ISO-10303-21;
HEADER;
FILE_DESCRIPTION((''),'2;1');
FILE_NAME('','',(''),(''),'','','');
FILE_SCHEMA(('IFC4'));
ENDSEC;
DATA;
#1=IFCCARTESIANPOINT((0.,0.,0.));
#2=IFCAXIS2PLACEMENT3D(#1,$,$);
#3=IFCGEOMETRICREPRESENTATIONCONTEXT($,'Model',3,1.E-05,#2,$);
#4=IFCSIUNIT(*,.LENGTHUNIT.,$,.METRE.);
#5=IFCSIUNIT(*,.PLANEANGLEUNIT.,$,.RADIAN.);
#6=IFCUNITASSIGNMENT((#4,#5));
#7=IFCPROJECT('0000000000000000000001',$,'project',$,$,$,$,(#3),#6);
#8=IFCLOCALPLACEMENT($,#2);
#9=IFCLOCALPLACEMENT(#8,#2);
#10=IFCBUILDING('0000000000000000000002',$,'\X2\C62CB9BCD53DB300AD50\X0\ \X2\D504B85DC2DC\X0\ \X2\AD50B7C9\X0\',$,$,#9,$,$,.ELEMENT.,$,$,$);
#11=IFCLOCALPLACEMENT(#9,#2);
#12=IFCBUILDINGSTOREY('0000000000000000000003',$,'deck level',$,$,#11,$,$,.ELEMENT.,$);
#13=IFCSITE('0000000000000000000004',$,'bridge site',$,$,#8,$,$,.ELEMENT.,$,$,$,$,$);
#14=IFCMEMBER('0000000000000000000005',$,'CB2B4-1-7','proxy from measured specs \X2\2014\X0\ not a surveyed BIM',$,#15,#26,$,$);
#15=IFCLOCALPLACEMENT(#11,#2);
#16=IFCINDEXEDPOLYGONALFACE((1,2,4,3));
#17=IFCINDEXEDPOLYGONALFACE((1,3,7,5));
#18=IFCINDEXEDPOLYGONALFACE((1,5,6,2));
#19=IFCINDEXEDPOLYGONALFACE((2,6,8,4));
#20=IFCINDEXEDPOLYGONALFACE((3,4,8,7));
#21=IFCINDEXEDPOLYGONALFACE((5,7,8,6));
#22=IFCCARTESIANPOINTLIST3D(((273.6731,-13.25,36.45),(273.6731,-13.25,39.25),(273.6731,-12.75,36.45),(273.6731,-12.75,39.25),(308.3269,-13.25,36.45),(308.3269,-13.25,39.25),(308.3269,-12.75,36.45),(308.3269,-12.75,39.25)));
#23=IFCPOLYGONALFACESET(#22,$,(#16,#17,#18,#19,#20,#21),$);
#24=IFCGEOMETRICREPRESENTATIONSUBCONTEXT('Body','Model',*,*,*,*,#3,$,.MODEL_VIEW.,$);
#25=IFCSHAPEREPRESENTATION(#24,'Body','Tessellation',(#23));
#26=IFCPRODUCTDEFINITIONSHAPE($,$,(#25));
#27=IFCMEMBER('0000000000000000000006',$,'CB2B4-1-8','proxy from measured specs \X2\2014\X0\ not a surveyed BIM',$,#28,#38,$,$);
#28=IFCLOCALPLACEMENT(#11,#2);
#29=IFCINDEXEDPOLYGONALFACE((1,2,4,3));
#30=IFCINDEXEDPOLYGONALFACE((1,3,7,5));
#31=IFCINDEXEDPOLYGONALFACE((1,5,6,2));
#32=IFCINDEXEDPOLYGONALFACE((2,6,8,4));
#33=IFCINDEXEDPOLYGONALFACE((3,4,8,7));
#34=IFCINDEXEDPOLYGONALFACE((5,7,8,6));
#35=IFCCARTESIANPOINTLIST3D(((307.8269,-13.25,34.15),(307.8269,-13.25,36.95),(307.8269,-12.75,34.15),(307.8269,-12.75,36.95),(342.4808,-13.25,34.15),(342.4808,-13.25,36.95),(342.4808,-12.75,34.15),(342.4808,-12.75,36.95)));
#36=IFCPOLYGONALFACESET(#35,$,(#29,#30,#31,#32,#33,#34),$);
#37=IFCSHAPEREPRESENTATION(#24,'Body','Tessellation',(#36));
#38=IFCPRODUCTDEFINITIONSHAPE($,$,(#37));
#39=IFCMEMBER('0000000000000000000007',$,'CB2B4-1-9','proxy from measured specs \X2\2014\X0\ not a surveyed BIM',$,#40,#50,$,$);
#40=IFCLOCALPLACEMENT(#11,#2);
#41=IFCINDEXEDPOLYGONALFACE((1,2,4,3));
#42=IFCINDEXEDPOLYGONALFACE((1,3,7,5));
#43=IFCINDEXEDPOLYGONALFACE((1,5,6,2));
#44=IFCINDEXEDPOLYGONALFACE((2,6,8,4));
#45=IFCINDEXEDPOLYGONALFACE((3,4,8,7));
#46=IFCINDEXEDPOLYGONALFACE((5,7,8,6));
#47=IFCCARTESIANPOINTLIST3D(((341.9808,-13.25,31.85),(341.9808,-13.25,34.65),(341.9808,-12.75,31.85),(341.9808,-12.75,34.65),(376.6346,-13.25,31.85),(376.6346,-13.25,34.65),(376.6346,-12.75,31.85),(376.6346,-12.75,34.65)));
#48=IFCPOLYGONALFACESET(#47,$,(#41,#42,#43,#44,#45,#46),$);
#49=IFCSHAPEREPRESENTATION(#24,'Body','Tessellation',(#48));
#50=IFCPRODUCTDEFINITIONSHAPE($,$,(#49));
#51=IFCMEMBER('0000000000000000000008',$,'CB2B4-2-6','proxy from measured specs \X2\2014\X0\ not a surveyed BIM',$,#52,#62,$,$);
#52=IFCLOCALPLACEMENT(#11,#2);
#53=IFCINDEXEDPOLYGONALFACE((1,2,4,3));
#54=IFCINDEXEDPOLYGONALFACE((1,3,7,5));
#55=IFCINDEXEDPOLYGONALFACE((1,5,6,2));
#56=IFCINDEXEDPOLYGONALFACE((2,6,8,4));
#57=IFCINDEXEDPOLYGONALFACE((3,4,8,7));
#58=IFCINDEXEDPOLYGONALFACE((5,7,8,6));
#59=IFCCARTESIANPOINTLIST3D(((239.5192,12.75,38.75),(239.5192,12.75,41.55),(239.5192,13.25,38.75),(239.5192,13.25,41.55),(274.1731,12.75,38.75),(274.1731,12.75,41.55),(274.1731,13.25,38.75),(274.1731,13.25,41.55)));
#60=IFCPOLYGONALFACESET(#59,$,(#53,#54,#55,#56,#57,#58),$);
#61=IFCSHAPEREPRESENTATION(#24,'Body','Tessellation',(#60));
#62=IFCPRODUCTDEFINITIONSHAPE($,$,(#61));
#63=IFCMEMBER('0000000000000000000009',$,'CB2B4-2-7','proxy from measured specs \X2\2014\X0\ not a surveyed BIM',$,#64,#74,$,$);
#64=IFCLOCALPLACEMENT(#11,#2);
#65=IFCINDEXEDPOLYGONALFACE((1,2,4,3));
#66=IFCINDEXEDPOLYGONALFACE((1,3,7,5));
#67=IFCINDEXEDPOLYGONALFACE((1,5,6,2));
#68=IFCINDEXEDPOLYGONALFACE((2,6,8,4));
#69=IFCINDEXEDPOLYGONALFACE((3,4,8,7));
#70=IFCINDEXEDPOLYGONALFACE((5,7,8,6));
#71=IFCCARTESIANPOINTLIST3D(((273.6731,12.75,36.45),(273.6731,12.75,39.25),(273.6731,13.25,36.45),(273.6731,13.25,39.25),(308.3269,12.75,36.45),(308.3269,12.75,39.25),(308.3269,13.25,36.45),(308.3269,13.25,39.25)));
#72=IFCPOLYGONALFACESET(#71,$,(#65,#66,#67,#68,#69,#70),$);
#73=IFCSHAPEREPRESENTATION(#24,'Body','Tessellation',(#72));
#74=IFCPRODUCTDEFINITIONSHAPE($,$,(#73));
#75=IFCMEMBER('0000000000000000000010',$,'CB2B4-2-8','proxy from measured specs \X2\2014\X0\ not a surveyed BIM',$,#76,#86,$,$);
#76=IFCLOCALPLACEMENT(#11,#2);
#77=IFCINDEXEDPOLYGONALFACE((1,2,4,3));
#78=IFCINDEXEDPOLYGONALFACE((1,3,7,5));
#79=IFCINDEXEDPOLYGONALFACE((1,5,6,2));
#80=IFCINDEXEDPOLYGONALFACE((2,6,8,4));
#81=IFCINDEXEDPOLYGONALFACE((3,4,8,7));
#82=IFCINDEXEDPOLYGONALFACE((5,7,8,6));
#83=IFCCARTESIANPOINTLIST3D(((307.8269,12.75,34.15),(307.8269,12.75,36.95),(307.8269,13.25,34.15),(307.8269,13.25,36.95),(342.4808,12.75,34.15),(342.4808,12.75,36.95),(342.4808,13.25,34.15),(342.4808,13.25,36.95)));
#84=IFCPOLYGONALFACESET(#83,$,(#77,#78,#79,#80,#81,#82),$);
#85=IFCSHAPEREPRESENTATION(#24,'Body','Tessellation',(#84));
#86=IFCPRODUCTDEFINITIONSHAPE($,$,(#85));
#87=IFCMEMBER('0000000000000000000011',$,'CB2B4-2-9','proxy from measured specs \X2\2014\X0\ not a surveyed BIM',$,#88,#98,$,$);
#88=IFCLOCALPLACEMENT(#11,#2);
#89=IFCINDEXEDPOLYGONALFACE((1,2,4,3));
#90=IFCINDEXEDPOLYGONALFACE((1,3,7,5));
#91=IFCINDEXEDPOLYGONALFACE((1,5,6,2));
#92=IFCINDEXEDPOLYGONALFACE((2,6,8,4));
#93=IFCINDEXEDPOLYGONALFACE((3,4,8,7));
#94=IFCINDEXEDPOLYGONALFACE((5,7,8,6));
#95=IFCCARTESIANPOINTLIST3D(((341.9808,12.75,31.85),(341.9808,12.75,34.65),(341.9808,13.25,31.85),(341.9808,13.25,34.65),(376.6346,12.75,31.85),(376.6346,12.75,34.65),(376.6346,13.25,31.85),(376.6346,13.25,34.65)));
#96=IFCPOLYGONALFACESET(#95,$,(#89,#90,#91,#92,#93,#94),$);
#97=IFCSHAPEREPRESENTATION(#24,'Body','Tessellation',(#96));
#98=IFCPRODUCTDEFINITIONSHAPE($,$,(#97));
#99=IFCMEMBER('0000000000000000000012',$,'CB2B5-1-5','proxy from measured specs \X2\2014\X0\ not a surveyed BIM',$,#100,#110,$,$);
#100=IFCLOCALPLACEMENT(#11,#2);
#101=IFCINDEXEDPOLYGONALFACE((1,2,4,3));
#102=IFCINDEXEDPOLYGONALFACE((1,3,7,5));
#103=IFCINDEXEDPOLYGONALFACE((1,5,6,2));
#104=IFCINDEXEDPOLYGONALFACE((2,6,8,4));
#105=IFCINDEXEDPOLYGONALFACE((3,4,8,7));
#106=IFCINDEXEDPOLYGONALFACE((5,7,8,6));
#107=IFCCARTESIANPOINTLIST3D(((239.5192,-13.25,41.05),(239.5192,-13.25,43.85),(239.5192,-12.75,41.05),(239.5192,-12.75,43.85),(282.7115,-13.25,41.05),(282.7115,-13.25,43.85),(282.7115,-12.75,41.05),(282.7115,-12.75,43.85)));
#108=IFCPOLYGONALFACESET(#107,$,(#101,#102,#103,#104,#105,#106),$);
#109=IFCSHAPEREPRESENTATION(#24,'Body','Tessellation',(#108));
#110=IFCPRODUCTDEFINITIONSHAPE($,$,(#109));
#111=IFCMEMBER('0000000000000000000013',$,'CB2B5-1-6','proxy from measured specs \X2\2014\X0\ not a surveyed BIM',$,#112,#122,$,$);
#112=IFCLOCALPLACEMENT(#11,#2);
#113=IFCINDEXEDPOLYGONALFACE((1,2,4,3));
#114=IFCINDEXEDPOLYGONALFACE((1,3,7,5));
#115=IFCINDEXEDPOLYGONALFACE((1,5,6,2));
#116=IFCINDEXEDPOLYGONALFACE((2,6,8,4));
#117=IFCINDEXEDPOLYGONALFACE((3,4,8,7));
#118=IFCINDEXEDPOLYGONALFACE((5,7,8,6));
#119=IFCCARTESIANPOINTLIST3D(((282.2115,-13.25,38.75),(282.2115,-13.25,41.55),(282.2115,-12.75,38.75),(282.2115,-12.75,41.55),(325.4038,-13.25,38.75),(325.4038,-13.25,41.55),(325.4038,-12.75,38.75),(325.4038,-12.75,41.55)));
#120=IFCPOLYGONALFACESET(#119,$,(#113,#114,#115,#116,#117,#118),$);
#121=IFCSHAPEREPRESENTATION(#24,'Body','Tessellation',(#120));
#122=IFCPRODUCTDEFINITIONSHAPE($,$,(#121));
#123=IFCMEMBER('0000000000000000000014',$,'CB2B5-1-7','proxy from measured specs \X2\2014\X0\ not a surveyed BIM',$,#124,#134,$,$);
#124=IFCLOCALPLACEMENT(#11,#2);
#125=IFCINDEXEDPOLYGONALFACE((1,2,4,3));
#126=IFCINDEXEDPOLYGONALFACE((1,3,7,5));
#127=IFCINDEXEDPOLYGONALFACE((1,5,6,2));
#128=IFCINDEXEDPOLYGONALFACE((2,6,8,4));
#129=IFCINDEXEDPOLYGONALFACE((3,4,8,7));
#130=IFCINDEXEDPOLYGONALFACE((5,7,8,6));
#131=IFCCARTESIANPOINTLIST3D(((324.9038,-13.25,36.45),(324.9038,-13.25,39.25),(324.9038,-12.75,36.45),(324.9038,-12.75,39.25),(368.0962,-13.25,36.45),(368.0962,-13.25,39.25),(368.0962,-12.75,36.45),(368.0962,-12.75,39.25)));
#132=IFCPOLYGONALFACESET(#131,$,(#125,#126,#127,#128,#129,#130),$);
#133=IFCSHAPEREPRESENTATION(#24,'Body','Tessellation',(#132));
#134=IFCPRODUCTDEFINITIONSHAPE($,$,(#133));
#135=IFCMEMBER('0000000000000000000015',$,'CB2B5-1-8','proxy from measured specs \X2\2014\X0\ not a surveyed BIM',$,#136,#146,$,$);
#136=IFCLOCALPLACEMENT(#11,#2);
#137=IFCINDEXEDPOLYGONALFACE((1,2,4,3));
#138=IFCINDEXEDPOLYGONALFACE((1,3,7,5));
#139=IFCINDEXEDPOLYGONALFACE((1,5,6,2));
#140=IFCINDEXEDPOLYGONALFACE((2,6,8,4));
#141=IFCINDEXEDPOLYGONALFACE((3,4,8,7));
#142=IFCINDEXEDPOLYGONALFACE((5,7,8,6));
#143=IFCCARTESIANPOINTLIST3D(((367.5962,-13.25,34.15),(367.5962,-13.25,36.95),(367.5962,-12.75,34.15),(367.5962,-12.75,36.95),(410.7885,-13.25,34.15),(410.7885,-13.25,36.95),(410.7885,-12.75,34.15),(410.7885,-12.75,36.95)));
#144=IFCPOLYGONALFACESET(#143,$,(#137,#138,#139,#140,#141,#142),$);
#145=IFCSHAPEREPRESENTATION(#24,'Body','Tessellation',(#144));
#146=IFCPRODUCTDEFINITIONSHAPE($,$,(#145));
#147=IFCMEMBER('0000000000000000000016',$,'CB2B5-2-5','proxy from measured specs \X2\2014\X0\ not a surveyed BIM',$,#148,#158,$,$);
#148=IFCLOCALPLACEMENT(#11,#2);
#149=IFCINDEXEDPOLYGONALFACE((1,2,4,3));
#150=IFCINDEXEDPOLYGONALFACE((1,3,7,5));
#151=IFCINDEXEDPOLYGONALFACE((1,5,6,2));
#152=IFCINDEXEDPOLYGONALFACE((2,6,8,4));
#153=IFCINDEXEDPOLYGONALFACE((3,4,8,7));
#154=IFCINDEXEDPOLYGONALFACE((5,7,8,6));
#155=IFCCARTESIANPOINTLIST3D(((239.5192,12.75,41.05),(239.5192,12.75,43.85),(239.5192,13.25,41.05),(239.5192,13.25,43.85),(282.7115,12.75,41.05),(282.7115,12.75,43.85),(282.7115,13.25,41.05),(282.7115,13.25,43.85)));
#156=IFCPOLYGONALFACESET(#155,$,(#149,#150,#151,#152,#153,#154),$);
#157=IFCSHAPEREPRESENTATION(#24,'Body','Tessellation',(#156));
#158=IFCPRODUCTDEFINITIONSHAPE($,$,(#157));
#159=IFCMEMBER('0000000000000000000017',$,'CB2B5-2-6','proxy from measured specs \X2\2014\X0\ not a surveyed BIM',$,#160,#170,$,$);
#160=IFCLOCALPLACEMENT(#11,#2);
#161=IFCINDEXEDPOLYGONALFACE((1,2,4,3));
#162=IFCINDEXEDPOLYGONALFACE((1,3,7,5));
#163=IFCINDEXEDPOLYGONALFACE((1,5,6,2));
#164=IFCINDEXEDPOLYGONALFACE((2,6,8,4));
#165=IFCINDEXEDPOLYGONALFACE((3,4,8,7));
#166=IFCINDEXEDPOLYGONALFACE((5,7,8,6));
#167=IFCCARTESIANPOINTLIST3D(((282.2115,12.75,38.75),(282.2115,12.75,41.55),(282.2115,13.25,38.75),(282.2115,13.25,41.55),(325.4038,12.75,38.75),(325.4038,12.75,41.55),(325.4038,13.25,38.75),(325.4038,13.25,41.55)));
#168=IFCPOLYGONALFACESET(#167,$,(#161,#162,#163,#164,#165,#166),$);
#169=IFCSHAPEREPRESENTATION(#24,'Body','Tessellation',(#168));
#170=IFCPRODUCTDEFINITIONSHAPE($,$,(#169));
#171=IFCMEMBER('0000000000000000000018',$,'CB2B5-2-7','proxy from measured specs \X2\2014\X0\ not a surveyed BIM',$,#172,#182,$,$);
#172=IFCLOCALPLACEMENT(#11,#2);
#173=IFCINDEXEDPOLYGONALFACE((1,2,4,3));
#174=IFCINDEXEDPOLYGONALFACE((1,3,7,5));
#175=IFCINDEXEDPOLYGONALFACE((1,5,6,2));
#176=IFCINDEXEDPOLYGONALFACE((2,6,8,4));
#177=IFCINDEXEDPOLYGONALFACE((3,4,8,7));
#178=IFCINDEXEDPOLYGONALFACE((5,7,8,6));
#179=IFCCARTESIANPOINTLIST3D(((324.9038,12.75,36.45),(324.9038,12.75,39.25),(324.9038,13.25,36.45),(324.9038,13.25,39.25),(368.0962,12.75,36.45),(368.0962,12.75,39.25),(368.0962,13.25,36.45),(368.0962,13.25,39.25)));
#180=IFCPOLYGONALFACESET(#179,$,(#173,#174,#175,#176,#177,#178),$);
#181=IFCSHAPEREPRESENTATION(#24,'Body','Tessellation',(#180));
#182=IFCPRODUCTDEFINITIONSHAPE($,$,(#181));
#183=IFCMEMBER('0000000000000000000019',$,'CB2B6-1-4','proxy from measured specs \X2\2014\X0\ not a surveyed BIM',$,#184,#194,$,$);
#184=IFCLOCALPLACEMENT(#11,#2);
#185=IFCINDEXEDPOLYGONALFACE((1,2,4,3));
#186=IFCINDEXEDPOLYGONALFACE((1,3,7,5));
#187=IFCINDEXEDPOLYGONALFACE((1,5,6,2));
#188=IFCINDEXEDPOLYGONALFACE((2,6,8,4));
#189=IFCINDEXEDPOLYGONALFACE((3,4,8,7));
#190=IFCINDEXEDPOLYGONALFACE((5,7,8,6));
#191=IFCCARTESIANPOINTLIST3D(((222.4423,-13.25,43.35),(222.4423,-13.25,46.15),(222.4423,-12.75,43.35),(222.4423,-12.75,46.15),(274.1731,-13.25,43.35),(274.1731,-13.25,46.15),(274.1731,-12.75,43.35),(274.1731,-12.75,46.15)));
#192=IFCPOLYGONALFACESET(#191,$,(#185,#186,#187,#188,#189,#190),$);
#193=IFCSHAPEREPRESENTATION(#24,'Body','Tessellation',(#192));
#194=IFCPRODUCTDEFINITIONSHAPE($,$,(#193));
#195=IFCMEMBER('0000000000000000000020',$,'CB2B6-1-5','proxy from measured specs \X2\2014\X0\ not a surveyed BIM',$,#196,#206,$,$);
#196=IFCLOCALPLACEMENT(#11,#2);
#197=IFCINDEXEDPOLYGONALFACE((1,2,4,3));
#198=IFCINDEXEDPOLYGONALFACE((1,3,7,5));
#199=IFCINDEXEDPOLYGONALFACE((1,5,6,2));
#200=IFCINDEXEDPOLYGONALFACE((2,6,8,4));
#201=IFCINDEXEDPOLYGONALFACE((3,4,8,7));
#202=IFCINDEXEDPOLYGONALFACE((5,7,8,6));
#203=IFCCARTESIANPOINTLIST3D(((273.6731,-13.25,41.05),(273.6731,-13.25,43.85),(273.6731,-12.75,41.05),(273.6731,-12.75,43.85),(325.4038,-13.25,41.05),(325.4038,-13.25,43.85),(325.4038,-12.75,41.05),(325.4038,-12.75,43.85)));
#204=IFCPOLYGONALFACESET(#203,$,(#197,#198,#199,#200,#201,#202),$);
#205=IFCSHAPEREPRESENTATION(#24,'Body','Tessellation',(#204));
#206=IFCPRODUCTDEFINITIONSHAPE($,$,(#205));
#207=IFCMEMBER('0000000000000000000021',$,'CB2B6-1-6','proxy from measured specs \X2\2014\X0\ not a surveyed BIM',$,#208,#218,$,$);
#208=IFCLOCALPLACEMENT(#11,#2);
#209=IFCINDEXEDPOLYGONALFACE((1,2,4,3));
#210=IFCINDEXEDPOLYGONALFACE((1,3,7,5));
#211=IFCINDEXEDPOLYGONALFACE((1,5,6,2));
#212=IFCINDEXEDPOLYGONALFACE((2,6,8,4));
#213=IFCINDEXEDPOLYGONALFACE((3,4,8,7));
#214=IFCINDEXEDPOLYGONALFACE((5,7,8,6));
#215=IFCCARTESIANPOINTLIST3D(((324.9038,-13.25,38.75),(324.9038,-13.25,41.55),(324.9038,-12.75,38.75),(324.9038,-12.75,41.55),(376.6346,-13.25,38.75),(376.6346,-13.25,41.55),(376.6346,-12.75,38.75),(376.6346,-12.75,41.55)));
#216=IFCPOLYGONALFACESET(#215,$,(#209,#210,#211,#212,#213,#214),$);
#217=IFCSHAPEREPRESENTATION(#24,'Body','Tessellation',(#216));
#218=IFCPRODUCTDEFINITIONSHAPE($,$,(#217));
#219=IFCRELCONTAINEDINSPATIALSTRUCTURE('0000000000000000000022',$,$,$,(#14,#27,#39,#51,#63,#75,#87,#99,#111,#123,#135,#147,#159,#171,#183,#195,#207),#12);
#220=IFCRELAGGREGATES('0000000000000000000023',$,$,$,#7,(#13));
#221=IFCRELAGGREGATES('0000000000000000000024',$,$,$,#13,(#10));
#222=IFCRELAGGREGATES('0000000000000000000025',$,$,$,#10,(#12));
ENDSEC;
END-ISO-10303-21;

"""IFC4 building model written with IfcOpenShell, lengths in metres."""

from ifc_helpers import new_model, si_unit, frame, origin, origin_2d, place, context, subcontext, project, spatial, rectangle, extrude, element, save


model = new_model("IFC4")

# Units and contexts
model_context = context("Model", 3, precision=1e-05, world=origin())
body_context = subcontext(model_context, "Body", "Model", "MODEL_VIEW")
ifc_project = project(units=[si_unit("LENGTHUNIT", "METRE"), si_unit("PLANEANGLEUNIT", "RADIAN")], contexts=[model_context])

# Site, building, storey
site_placement = place(None, origin())
site = spatial("IfcSite", under=ifc_project, at=site_placement, Name="bridge site", CompositionType="ELEMENT")
building_placement = place(site_placement, origin())
building = spatial("IfcBuilding", under=site, at=building_placement, Name="올림픽대교 프록시 교량", CompositionType="ELEMENT")
storey_placement = place(building_placement, origin())
storey = spatial("IfcBuildingStorey", under=building, at=storey_placement, Name="deck level", CompositionType="ELEMENT")

# Members
member_1_placement = place(storey_placement, frame((291.0, -13.0, 36.45)))
element("IfcMember", 1, at=member_1_placement, inside=storey, Name="CB2B4-1-7", Description="proxy from measured specs — not a surveyed BIM", context=body_context, shape_type="SweptSolid", body=[
    extrude(rectangle(XDim=34.6538, YDim=0.5, at=origin_2d()), origin(), (0.0, 0.0, 1.0), 2.8),
])
member_2_placement = place(storey_placement, frame((325.1538, -13.0, 34.15)))
element("IfcMember", 2, at=member_2_placement, inside=storey, Name="CB2B4-1-8", Description="proxy from measured specs — not a surveyed BIM", context=body_context, shape_type="SweptSolid", body=[
    extrude(rectangle(XDim=34.6538, YDim=0.5, at=origin_2d()), origin(), (0.0, 0.0, 1.0), 2.8),
])
member_3_placement = place(storey_placement, frame((359.3077, -13.0, 31.85)))
element("IfcMember", 3, at=member_3_placement, inside=storey, Name="CB2B4-1-9", Description="proxy from measured specs — not a surveyed BIM", context=body_context, shape_type="SweptSolid", body=[
    extrude(rectangle(XDim=34.6538, YDim=0.5, at=origin_2d()), origin(), (0.0, 0.0, 1.0), 2.8),
])
member_4_placement = place(storey_placement, frame((256.8462, 13.0, 38.75)))
element("IfcMember", 4, at=member_4_placement, inside=storey, Name="CB2B4-2-6", Description="proxy from measured specs — not a surveyed BIM", context=body_context, shape_type="SweptSolid", body=[
    extrude(rectangle(XDim=34.6538, YDim=0.5, at=origin_2d()), origin(), (0.0, 0.0, 1.0), 2.8),
])
member_5_placement = place(storey_placement, frame((291.0, 13.0, 36.45)))
element("IfcMember", 5, at=member_5_placement, inside=storey, Name="CB2B4-2-7", Description="proxy from measured specs — not a surveyed BIM", context=body_context, shape_type="SweptSolid", body=[
    extrude(rectangle(XDim=34.6538, YDim=0.5, at=origin_2d()), origin(), (0.0, 0.0, 1.0), 2.8),
])
member_6_placement = place(storey_placement, frame((325.1538, 13.0, 34.15)))
element("IfcMember", 6, at=member_6_placement, inside=storey, Name="CB2B4-2-8", Description="proxy from measured specs — not a surveyed BIM", context=body_context, shape_type="SweptSolid", body=[
    extrude(rectangle(XDim=34.6538, YDim=0.5, at=origin_2d()), origin(), (0.0, 0.0, 1.0), 2.8),
])
member_7_placement = place(storey_placement, frame((359.3077, 13.0, 31.85)))
element("IfcMember", 7, at=member_7_placement, inside=storey, Name="CB2B4-2-9", Description="proxy from measured specs — not a surveyed BIM", context=body_context, shape_type="SweptSolid", body=[
    extrude(rectangle(XDim=34.6538, YDim=0.5, at=origin_2d()), origin(), (0.0, 0.0, 1.0), 2.8),
])
member_8_placement = place(storey_placement, frame((261.1154, -13.0, 41.05)))
element("IfcMember", 8, at=member_8_placement, inside=storey, Name="CB2B5-1-5", Description="proxy from measured specs — not a surveyed BIM", context=body_context, shape_type="SweptSolid", body=[
    extrude(rectangle(XDim=43.1923, YDim=0.5, at=origin_2d()), origin(), (0.0, 0.0, 1.0), 2.8),
])
for number, where, name in (
    (9, (303.8077, -13.0, 38.75), "CB2B5-1-6"),
    (10, (346.5, -13.0, 36.45), "CB2B5-1-7"),
):
    element("IfcMember", number, at=place(storey_placement, frame(where)), inside=storey, Name=name, Description="proxy from measured specs — not a surveyed BIM", context=body_context, shape_type="SweptSolid", body=[
        extrude(rectangle(XDim=43.1923, YDim=0.5, at=origin_2d()), origin(), (0.0, 0.0, 1.0), 2.8),
    ])
member_9_placement = place(storey_placement, frame((389.1923, -13.0, 34.15)))
element("IfcMember", 11, at=member_9_placement, inside=storey, Name="CB2B5-1-8", Description="proxy from measured specs — not a surveyed BIM", context=body_context, shape_type="SweptSolid", body=[
    extrude(rectangle(XDim=43.1923, YDim=0.5, at=origin_2d()), origin(), (0.0, 0.0, 1.0), 2.8),
])
member_10_placement = place(storey_placement, frame((261.1154, 13.0, 41.05)))
element("IfcMember", 12, at=member_10_placement, inside=storey, Name="CB2B5-2-5", Description="proxy from measured specs — not a surveyed BIM", context=body_context, shape_type="SweptSolid", body=[
    extrude(rectangle(XDim=43.1923, YDim=0.5, at=origin_2d()), origin(), (0.0, 0.0, 1.0), 2.8),
])
for number, where, name in (
    (13, (303.8077, 13.0, 38.75), "CB2B5-2-6"),
    (14, (346.5, 13.0, 36.45), "CB2B5-2-7"),
):
    element("IfcMember", number, at=place(storey_placement, frame(where)), inside=storey, Name=name, Description="proxy from measured specs — not a surveyed BIM", context=body_context, shape_type="SweptSolid", body=[
        extrude(rectangle(XDim=43.1923, YDim=0.5, at=origin_2d()), origin(), (0.0, 0.0, 1.0), 2.8),
    ])
member_11_placement = place(storey_placement, frame((248.3077, -13.0, 43.35)))
element("IfcMember", 15, at=member_11_placement, inside=storey, Name="CB2B6-1-4", Description="proxy from measured specs — not a surveyed BIM", context=body_context, shape_type="SweptSolid", body=[
    extrude(rectangle(XDim=51.7308, YDim=0.5, at=origin_2d()), origin(), (0.0, 0.0, 1.0), 2.8),
])
for number, where, name in (
    (16, (299.5385, -13.0, 41.05), "CB2B6-1-5"),
    (17, (350.7692, -13.0, 38.75), "CB2B6-1-6"),
):
    element("IfcMember", number, at=place(storey_placement, frame(where)), inside=storey, Name=name, Description="proxy from measured specs — not a surveyed BIM", context=body_context, shape_type="SweptSolid", body=[
        extrude(rectangle(XDim=51.7308, YDim=0.5, at=origin_2d()), origin(), (0.0, 0.0, 1.0), 2.8),
    ])

save(model, "model.ifc")
